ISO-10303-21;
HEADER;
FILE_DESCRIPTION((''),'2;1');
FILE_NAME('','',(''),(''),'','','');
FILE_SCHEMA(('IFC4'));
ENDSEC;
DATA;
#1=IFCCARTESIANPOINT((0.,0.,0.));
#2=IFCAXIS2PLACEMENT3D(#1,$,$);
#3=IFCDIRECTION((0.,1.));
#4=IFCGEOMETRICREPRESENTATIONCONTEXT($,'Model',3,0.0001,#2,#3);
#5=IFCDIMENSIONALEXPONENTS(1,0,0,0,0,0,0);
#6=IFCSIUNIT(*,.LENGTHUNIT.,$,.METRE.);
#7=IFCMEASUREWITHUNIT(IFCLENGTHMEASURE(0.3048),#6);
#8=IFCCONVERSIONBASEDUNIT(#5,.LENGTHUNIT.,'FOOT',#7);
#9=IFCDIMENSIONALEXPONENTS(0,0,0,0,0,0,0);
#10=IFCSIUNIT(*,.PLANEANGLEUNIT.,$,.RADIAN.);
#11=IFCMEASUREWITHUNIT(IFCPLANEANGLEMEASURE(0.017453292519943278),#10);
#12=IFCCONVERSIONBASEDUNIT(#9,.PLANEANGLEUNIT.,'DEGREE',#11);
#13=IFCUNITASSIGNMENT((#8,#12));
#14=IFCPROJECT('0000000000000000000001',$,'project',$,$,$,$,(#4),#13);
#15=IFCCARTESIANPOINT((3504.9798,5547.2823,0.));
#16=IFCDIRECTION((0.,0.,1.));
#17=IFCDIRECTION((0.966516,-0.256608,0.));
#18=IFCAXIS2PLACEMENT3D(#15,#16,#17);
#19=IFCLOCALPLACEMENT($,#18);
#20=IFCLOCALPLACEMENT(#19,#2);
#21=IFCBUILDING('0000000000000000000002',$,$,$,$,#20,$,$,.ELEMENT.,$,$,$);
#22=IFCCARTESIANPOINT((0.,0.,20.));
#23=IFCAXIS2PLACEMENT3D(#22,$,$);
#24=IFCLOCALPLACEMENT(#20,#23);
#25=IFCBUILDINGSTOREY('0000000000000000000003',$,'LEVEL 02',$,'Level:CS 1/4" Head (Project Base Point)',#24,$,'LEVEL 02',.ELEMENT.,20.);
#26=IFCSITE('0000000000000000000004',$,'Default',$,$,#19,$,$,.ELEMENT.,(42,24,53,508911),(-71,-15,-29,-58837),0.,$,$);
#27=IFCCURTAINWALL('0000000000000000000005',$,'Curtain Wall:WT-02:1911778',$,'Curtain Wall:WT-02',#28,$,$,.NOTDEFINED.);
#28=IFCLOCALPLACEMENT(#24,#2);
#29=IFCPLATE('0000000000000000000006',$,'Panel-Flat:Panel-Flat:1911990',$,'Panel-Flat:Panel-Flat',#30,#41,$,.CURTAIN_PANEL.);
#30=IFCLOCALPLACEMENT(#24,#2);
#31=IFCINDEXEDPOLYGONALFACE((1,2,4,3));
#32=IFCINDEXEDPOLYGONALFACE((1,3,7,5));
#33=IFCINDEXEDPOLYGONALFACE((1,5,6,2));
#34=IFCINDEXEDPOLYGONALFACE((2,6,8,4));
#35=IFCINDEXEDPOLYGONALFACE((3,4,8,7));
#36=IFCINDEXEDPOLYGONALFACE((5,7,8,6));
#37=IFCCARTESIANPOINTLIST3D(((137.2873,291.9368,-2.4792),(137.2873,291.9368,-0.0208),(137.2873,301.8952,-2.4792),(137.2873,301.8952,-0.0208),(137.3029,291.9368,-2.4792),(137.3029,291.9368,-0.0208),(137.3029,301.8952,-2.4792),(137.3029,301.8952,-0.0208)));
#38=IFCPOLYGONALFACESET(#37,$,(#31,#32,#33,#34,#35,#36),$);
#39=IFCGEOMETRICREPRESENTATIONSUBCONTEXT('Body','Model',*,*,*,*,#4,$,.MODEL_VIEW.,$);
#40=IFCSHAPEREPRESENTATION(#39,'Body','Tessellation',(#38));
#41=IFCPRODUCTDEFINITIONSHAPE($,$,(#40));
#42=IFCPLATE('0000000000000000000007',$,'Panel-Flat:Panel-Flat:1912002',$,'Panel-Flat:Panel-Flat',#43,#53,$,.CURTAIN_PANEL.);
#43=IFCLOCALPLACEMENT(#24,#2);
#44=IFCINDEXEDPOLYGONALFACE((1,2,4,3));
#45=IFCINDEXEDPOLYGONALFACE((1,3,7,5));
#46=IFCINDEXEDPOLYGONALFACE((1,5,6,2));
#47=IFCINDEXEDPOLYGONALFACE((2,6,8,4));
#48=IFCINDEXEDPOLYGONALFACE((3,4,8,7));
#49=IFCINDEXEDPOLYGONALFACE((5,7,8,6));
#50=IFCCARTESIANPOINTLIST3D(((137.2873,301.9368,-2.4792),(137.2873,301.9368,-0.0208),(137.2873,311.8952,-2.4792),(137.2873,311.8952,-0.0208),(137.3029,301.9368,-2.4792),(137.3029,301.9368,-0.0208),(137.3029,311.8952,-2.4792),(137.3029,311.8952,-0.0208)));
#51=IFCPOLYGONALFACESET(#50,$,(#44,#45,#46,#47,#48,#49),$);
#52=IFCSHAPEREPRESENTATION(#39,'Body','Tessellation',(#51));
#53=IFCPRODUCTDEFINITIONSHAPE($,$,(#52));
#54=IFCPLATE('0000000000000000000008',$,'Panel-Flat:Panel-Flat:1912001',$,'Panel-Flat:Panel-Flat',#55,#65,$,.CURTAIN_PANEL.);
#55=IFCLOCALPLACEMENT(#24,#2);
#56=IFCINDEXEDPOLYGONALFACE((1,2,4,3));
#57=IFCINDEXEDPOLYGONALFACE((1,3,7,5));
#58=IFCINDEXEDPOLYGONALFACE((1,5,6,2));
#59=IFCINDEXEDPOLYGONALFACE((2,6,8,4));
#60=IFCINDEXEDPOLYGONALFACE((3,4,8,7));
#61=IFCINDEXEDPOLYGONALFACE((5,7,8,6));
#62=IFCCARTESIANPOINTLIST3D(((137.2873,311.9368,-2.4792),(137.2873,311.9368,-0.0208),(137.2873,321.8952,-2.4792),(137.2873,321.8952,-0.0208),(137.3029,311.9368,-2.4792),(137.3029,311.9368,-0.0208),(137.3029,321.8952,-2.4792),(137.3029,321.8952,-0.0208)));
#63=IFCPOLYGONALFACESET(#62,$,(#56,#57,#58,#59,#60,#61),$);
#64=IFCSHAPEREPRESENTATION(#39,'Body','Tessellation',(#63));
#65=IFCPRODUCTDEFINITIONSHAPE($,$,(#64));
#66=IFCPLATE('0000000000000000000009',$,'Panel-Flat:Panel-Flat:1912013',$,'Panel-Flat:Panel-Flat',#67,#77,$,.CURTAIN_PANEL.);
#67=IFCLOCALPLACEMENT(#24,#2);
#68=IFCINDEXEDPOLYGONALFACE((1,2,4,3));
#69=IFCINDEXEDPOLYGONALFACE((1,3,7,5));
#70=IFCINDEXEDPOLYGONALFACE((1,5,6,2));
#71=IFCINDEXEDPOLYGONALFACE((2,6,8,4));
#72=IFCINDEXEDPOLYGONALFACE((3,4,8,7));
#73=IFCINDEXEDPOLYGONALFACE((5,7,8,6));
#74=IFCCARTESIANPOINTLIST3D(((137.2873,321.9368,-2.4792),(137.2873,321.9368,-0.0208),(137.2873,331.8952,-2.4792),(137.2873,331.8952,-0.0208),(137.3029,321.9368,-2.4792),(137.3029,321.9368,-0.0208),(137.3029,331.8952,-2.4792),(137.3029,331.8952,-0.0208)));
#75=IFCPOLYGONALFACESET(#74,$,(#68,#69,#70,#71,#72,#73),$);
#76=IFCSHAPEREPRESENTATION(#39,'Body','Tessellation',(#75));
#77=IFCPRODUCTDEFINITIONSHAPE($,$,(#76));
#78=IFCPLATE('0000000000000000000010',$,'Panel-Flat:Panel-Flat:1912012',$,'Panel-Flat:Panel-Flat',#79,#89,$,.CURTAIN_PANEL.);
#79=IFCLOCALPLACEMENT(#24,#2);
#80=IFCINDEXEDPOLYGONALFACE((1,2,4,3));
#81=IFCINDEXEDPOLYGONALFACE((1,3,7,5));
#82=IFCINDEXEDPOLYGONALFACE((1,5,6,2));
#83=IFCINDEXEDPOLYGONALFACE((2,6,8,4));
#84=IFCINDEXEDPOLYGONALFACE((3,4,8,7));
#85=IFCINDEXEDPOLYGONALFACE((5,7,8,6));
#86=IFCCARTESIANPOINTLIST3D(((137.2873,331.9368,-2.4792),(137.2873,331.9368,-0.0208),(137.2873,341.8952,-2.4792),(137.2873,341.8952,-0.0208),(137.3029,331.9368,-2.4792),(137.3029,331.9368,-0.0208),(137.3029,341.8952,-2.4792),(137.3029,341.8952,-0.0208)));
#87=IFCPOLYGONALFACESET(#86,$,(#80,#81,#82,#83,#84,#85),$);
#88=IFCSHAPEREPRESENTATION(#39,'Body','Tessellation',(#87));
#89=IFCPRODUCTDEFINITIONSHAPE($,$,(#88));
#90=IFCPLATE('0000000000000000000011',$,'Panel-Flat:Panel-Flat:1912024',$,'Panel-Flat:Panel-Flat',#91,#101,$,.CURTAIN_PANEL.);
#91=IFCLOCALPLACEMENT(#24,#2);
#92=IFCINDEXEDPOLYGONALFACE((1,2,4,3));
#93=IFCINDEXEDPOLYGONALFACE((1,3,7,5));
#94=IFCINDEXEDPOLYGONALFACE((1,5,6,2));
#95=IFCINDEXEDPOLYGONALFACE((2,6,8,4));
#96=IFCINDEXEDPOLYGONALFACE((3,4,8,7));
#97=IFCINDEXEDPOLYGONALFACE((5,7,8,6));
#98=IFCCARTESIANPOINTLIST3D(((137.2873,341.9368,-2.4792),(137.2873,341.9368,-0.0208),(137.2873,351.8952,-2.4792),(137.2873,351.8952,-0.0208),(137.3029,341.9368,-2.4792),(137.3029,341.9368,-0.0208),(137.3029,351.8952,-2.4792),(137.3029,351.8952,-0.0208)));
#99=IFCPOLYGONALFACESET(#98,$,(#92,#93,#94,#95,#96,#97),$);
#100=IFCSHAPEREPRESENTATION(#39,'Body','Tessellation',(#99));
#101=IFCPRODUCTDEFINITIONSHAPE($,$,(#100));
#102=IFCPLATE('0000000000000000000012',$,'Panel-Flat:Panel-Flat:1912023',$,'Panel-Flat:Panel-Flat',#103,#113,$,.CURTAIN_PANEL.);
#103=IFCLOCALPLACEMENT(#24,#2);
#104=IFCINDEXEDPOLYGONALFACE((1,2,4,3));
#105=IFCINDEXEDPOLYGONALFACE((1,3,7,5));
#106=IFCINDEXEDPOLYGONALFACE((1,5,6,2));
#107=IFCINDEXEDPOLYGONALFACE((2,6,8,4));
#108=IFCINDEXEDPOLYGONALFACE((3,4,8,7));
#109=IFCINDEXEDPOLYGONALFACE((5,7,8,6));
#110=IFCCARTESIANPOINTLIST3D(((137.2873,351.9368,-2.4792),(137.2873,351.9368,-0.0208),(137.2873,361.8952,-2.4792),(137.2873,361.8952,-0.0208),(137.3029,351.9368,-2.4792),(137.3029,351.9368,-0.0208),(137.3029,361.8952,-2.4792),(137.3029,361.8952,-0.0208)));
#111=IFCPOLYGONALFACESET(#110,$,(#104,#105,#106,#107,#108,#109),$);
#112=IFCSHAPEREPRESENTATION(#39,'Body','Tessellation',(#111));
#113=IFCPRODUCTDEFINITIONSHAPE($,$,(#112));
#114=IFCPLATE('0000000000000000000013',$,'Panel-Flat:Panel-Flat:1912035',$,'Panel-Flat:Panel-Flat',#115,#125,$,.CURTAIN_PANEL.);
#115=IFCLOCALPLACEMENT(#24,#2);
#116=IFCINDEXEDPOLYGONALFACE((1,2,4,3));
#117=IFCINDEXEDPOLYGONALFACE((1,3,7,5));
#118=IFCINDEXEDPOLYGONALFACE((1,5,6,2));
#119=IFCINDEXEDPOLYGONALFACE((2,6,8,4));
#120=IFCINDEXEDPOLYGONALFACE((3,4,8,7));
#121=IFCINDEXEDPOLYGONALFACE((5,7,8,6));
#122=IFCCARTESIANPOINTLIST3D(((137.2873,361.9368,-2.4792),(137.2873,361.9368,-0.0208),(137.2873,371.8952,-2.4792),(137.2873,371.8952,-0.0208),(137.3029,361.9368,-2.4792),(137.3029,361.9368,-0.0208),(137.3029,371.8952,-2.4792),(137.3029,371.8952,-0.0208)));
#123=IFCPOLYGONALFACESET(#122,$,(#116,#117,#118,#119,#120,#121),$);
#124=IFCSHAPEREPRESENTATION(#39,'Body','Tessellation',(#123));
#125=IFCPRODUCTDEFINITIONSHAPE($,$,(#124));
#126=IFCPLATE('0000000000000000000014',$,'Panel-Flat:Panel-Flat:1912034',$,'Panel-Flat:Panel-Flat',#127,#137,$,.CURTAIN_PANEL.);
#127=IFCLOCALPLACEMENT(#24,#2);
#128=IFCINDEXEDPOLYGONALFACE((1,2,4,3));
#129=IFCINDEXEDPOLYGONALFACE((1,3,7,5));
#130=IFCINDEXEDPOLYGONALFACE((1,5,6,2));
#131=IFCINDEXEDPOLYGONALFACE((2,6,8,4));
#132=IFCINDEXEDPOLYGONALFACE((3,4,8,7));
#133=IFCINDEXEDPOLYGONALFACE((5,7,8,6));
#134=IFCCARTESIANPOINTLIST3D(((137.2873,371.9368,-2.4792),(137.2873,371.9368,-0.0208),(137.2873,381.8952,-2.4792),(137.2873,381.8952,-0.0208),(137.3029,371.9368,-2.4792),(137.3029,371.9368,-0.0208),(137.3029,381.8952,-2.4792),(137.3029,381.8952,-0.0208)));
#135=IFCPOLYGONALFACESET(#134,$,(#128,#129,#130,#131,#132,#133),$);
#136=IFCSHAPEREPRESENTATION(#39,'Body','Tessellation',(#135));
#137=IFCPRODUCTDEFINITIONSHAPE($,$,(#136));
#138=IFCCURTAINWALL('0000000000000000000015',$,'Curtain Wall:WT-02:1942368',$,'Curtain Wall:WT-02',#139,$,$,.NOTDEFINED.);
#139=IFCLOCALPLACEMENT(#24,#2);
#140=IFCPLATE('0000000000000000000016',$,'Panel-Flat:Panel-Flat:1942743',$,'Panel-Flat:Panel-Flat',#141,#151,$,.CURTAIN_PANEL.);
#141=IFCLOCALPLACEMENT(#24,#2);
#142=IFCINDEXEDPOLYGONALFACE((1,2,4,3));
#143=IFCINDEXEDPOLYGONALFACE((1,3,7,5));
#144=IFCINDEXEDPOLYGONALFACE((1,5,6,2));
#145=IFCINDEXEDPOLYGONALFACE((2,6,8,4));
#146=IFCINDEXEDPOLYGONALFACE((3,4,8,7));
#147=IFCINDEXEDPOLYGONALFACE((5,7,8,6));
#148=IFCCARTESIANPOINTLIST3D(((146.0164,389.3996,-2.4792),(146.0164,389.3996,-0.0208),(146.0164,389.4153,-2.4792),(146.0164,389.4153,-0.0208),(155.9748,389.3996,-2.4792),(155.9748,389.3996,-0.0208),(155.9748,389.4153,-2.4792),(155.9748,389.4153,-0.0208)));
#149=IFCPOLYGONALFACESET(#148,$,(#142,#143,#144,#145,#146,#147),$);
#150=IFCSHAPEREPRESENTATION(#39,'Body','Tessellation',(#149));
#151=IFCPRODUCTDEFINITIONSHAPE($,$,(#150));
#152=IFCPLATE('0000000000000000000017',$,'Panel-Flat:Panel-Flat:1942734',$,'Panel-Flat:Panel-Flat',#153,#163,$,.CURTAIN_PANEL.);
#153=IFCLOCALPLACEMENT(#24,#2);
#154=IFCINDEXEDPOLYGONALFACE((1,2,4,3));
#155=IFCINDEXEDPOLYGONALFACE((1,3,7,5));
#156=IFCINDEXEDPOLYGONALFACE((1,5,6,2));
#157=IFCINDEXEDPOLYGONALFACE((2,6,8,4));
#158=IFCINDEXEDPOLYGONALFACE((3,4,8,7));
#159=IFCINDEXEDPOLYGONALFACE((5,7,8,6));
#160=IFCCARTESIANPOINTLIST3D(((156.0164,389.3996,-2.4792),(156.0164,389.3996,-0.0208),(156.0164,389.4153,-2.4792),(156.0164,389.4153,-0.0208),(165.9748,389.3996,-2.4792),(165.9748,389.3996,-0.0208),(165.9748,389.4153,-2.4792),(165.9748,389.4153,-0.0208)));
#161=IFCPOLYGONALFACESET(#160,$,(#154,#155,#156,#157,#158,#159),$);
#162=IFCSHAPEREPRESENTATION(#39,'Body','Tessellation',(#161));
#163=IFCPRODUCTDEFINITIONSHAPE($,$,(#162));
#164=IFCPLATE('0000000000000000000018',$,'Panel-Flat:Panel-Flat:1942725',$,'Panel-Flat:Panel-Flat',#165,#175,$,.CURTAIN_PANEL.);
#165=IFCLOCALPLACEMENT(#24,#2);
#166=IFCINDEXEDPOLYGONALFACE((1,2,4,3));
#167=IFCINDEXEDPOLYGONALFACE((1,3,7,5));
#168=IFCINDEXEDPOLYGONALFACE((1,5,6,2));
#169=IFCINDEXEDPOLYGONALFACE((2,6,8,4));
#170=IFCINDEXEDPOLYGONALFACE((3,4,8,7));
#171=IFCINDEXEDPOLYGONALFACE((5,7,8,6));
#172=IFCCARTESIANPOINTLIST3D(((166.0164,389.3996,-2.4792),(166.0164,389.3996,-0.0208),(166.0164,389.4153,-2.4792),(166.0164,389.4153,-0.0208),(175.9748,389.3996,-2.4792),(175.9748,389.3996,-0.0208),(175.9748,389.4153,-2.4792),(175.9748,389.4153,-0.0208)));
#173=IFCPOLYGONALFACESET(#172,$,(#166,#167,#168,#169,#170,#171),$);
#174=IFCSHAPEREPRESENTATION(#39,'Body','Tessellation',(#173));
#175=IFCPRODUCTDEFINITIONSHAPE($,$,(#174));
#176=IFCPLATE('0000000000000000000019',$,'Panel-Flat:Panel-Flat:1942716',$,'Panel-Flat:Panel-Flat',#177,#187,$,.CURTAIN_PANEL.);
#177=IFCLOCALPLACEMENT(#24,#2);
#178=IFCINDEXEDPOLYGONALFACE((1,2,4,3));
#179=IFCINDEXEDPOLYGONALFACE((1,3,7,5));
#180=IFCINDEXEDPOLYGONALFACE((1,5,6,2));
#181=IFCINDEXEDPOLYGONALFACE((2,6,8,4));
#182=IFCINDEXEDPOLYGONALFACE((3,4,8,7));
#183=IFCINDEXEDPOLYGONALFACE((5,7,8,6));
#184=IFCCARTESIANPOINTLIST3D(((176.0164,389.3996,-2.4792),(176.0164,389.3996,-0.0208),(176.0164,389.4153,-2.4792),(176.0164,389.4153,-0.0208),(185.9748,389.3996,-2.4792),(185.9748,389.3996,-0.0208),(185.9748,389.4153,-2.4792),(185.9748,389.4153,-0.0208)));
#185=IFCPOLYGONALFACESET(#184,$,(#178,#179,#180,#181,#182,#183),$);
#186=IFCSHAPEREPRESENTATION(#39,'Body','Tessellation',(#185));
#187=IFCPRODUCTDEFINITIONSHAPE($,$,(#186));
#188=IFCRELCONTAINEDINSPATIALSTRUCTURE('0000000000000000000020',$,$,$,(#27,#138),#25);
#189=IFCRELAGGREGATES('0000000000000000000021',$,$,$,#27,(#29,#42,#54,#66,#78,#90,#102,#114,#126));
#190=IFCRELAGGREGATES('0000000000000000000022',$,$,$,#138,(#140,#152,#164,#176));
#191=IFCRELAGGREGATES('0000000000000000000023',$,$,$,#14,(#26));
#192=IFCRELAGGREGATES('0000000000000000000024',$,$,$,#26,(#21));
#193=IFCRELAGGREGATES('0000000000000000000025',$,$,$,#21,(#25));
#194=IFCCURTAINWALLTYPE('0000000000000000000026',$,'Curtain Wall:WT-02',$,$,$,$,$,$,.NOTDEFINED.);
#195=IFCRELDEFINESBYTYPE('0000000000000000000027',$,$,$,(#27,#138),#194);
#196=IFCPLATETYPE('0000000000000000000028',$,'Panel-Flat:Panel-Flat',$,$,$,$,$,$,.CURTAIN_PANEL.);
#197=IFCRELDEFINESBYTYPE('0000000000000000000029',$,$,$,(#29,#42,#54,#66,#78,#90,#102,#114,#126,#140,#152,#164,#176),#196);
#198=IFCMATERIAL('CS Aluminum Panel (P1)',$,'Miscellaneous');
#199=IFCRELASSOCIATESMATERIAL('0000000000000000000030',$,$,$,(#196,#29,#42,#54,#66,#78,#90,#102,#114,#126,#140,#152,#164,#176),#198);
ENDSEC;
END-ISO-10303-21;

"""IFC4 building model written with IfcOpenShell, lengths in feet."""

from ifc_helpers import new_model, entity, si_unit, converted_unit, direction, frame, origin, place, context, subcontext, project, spatial, indexed_curve, outline, extrude, source, transform, mapped, material, type_object, type_shapes, element, aggregate, save


model = new_model("IFC4")

# Units and contexts
model_context = context("Model", 3, precision=0.0001, world=origin(), true_north=direction((0.0, 1.0)))
body_context = subcontext(model_context, "Body", "Model", "MODEL_VIEW")
ifc_project = project(units=[converted_unit("LENGTHUNIT", "FOOT", entity("IfcLengthMeasure", 0.3048), si_unit("LENGTHUNIT", "METRE"), dimensions=[1, 0, 0, 0, 0, 0, 0]), converted_unit("PLANEANGLEUNIT", "DEGREE", entity("IfcPlaneAngleMeasure", 0.017453292519943278), si_unit("PLANEANGLEUNIT", "RADIAN"), dimensions=[0, 0, 0, 0, 0, 0, 0])], contexts=[model_context])

# Site, building, storey
site_placement = place(None, frame((3504.9798, 5547.2823, 0.0), z_axis=(0.0, 0.0, 1.0), x_axis=(0.966516, -0.256608, 0.0)))
site = spatial("IfcSite", under=ifc_project, at=site_placement, Name="Default", CompositionType="ELEMENT", RefLatitude=(42, 24, 53, 508911), RefLongitude=(-71, -15, -29, -58837), RefElevation=0.0)
building_placement = place(site_placement, origin())
building = spatial("IfcBuilding", under=site, at=building_placement, CompositionType="ELEMENT")
storey_placement = place(building_placement, frame((0.0, 0.0, 20.0)))
storey = spatial("IfcBuildingStorey", under=building, at=storey_placement, Name="LEVEL 02", ObjectType="Level:CS 1/4\" Head (Project Base Point)", LongName="LEVEL 02", CompositionType="ELEMENT", Elevation=20.0)

# Curtain walls, plates
curtain_wall_type_1 = type_object("IfcCurtainWallType", Name="Curtain Wall:WT-02", PredefinedType="NOTDEFINED")
curtain_wall_1_placement = place(storey_placement, frame((0.0, 0.0, -20.0)))
curtain_wall_1 = element("IfcCurtainWall", 1, at=curtain_wall_1_placement, inside=storey, type_object=curtain_wall_type_1, Name="Curtain Wall:WT-02:1911778", ObjectType="Curtain Wall:WT-02", PredefinedType="NOTDEFINED")
ifc_material_1 = material(Name="CS Aluminum Panel (P1)", Category="Miscellaneous")
plate_type_1 = type_object("IfcPlateType", Name="Panel-Flat:Panel-Flat", PredefinedType="CURTAIN_PANEL", material=ifc_material_1)
shared_shape_1 = source(origin(), body_context, "Body", "SweptSolid", [
    extrude(outline(indexed_curve([(-0.0078, -4.9792), (0.0078, -4.9792), (0.0078, 4.9792), (-0.0078, 4.9792), (-0.0078, -4.9792)], self_intersect=False)), frame((0.0, -0.0078, 0.0208), z_axis=(0.0, 0.0, 1.0), x_axis=(0.0, -1.0, 0.0)), (0.0, 0.0, 1.0), 2.4583),
])
type_shapes(plate_type_1, [shared_shape_1])
plate_1_placement = place(curtain_wall_1_placement, frame((137.2873, 296.916, 17.5), z_axis=(0.0, 0.0, 1.0), x_axis=(0.0, 1.0, 0.0)))
plate_1 = element("IfcPlate", 2, at=plate_1_placement, type_object=plate_type_1, material=ifc_material_1, Name="Panel-Flat:Panel-Flat:1911990", ObjectType="Panel-Flat:Panel-Flat", PredefinedType="CURTAIN_PANEL", context=body_context, shape_type="MappedRepresentation", body=[
    mapped(shared_shape_1, transform((0.0, 0.0, 0.0), scale=1.0)),
])
plate_2_placement = place(curtain_wall_1_placement, frame((137.2873, 306.916, 17.5), z_axis=(0.0, 0.0, 1.0), x_axis=(0.0, 1.0, 0.0)))
plate_2 = element("IfcPlate", 3, at=plate_2_placement, type_object=plate_type_1, material=ifc_material_1, Name="Panel-Flat:Panel-Flat:1912002", ObjectType="Panel-Flat:Panel-Flat", PredefinedType="CURTAIN_PANEL", context=body_context, shape_type="MappedRepresentation", body=[
    mapped(shared_shape_1, transform((0.0, 0.0, 0.0), scale=1.0)),
])
plate_3_placement = place(curtain_wall_1_placement, frame((137.2873, 316.916, 17.5), z_axis=(0.0, 0.0, 1.0), x_axis=(0.0, 1.0, 0.0)))
plate_3 = element("IfcPlate", 4, at=plate_3_placement, type_object=plate_type_1, material=ifc_material_1, Name="Panel-Flat:Panel-Flat:1912001", ObjectType="Panel-Flat:Panel-Flat", PredefinedType="CURTAIN_PANEL", context=body_context, shape_type="MappedRepresentation", body=[
    mapped(shared_shape_1, transform((0.0, 0.0, 0.0), scale=1.0)),
])
plate_4_placement = place(curtain_wall_1_placement, frame((137.2873, 326.916, 17.5), z_axis=(0.0, 0.0, 1.0), x_axis=(0.0, 1.0, 0.0)))
plate_4 = element("IfcPlate", 5, at=plate_4_placement, type_object=plate_type_1, material=ifc_material_1, Name="Panel-Flat:Panel-Flat:1912013", ObjectType="Panel-Flat:Panel-Flat", PredefinedType="CURTAIN_PANEL", context=body_context, shape_type="MappedRepresentation", body=[
    mapped(shared_shape_1, transform((0.0, 0.0, 0.0), scale=1.0)),
])
plate_5_placement = place(curtain_wall_1_placement, frame((137.2873, 336.916, 17.5), z_axis=(0.0, 0.0, 1.0), x_axis=(0.0, 1.0, 0.0)))
plate_5 = element("IfcPlate", 6, at=plate_5_placement, type_object=plate_type_1, material=ifc_material_1, Name="Panel-Flat:Panel-Flat:1912012", ObjectType="Panel-Flat:Panel-Flat", PredefinedType="CURTAIN_PANEL", context=body_context, shape_type="MappedRepresentation", body=[
    mapped(shared_shape_1, transform((0.0, 0.0, 0.0), scale=1.0)),
])
plate_6_placement = place(curtain_wall_1_placement, frame((137.2873, 346.916, 17.5), z_axis=(0.0, 0.0, 1.0), x_axis=(0.0, 1.0, 0.0)))
plate_6 = element("IfcPlate", 7, at=plate_6_placement, type_object=plate_type_1, material=ifc_material_1, Name="Panel-Flat:Panel-Flat:1912024", ObjectType="Panel-Flat:Panel-Flat", PredefinedType="CURTAIN_PANEL", context=body_context, shape_type="MappedRepresentation", body=[
    mapped(shared_shape_1, transform((0.0, 0.0, 0.0), scale=1.0)),
])
plate_7_placement = place(curtain_wall_1_placement, frame((137.2873, 356.916, 17.5), z_axis=(0.0, 0.0, 1.0), x_axis=(0.0, 1.0, 0.0)))
plate_7 = element("IfcPlate", 8, at=plate_7_placement, type_object=plate_type_1, material=ifc_material_1, Name="Panel-Flat:Panel-Flat:1912023", ObjectType="Panel-Flat:Panel-Flat", PredefinedType="CURTAIN_PANEL", context=body_context, shape_type="MappedRepresentation", body=[
    mapped(shared_shape_1, transform((0.0, 0.0, 0.0), scale=1.0)),
])
plate_8_placement = place(curtain_wall_1_placement, frame((137.2873, 366.916, 17.5), z_axis=(0.0, 0.0, 1.0), x_axis=(0.0, 1.0, 0.0)))
plate_8 = element("IfcPlate", 9, at=plate_8_placement, type_object=plate_type_1, material=ifc_material_1, Name="Panel-Flat:Panel-Flat:1912035", ObjectType="Panel-Flat:Panel-Flat", PredefinedType="CURTAIN_PANEL", context=body_context, shape_type="MappedRepresentation", body=[
    mapped(shared_shape_1, transform((0.0, 0.0, 0.0), scale=1.0)),
])
plate_9_placement = place(curtain_wall_1_placement, frame((137.2873, 376.916, 17.5), z_axis=(0.0, 0.0, 1.0), x_axis=(0.0, 1.0, 0.0)))
plate_9 = element("IfcPlate", 10, at=plate_9_placement, type_object=plate_type_1, material=ifc_material_1, Name="Panel-Flat:Panel-Flat:1912034", ObjectType="Panel-Flat:Panel-Flat", PredefinedType="CURTAIN_PANEL", context=body_context, shape_type="MappedRepresentation", body=[
    mapped(shared_shape_1, transform((0.0, 0.0, 0.0), scale=1.0)),
])
curtain_wall_2_placement = place(storey_placement, frame((0.0, 0.0, -20.0)))
curtain_wall_2 = element("IfcCurtainWall", 11, at=curtain_wall_2_placement, inside=storey, type_object=curtain_wall_type_1, Name="Curtain Wall:WT-02:1942368", ObjectType="Curtain Wall:WT-02", PredefinedType="NOTDEFINED")
plate_10_placement = place(curtain_wall_2_placement, frame((150.9956, 389.4153, 17.5)))
plate_10 = element("IfcPlate", 12, at=plate_10_placement, type_object=plate_type_1, material=ifc_material_1, Name="Panel-Flat:Panel-Flat:1942743", ObjectType="Panel-Flat:Panel-Flat", PredefinedType="CURTAIN_PANEL", context=body_context, shape_type="MappedRepresentation", body=[
    mapped(shared_shape_1, transform((0.0, 0.0, 0.0), scale=1.0)),
])
plate_11_placement = place(curtain_wall_2_placement, frame((160.9956, 389.4153, 17.5)))
plate_11 = element("IfcPlate", 13, at=plate_11_placement, type_object=plate_type_1, material=ifc_material_1, Name="Panel-Flat:Panel-Flat:1942734", ObjectType="Panel-Flat:Panel-Flat", PredefinedType="CURTAIN_PANEL", context=body_context, shape_type="MappedRepresentation", body=[
    mapped(shared_shape_1, transform((0.0, 0.0, 0.0), scale=1.0)),
])
plate_12_placement = place(curtain_wall_2_placement, frame((170.9956, 389.4153, 17.5)))
plate_12 = element("IfcPlate", 14, at=plate_12_placement, type_object=plate_type_1, material=ifc_material_1, Name="Panel-Flat:Panel-Flat:1942725", ObjectType="Panel-Flat:Panel-Flat", PredefinedType="CURTAIN_PANEL", context=body_context, shape_type="MappedRepresentation", body=[
    mapped(shared_shape_1, transform((0.0, 0.0, 0.0), scale=1.0)),
])
plate_13_placement = place(curtain_wall_2_placement, frame((180.9956, 389.4153, 17.5)))
plate_13 = element("IfcPlate", 15, at=plate_13_placement, type_object=plate_type_1, material=ifc_material_1, Name="Panel-Flat:Panel-Flat:1942716", ObjectType="Panel-Flat:Panel-Flat", PredefinedType="CURTAIN_PANEL", context=body_context, shape_type="MappedRepresentation", body=[
    mapped(shared_shape_1, transform((0.0, 0.0, 0.0), scale=1.0)),
])

aggregate(curtain_wall_1, [plate_1, plate_2, plate_3, plate_4, plate_5, plate_6, plate_7, plate_8, plate_9])
aggregate(curtain_wall_2, [plate_10, plate_11, plate_12, plate_13])

save(model, "model.ifc")
